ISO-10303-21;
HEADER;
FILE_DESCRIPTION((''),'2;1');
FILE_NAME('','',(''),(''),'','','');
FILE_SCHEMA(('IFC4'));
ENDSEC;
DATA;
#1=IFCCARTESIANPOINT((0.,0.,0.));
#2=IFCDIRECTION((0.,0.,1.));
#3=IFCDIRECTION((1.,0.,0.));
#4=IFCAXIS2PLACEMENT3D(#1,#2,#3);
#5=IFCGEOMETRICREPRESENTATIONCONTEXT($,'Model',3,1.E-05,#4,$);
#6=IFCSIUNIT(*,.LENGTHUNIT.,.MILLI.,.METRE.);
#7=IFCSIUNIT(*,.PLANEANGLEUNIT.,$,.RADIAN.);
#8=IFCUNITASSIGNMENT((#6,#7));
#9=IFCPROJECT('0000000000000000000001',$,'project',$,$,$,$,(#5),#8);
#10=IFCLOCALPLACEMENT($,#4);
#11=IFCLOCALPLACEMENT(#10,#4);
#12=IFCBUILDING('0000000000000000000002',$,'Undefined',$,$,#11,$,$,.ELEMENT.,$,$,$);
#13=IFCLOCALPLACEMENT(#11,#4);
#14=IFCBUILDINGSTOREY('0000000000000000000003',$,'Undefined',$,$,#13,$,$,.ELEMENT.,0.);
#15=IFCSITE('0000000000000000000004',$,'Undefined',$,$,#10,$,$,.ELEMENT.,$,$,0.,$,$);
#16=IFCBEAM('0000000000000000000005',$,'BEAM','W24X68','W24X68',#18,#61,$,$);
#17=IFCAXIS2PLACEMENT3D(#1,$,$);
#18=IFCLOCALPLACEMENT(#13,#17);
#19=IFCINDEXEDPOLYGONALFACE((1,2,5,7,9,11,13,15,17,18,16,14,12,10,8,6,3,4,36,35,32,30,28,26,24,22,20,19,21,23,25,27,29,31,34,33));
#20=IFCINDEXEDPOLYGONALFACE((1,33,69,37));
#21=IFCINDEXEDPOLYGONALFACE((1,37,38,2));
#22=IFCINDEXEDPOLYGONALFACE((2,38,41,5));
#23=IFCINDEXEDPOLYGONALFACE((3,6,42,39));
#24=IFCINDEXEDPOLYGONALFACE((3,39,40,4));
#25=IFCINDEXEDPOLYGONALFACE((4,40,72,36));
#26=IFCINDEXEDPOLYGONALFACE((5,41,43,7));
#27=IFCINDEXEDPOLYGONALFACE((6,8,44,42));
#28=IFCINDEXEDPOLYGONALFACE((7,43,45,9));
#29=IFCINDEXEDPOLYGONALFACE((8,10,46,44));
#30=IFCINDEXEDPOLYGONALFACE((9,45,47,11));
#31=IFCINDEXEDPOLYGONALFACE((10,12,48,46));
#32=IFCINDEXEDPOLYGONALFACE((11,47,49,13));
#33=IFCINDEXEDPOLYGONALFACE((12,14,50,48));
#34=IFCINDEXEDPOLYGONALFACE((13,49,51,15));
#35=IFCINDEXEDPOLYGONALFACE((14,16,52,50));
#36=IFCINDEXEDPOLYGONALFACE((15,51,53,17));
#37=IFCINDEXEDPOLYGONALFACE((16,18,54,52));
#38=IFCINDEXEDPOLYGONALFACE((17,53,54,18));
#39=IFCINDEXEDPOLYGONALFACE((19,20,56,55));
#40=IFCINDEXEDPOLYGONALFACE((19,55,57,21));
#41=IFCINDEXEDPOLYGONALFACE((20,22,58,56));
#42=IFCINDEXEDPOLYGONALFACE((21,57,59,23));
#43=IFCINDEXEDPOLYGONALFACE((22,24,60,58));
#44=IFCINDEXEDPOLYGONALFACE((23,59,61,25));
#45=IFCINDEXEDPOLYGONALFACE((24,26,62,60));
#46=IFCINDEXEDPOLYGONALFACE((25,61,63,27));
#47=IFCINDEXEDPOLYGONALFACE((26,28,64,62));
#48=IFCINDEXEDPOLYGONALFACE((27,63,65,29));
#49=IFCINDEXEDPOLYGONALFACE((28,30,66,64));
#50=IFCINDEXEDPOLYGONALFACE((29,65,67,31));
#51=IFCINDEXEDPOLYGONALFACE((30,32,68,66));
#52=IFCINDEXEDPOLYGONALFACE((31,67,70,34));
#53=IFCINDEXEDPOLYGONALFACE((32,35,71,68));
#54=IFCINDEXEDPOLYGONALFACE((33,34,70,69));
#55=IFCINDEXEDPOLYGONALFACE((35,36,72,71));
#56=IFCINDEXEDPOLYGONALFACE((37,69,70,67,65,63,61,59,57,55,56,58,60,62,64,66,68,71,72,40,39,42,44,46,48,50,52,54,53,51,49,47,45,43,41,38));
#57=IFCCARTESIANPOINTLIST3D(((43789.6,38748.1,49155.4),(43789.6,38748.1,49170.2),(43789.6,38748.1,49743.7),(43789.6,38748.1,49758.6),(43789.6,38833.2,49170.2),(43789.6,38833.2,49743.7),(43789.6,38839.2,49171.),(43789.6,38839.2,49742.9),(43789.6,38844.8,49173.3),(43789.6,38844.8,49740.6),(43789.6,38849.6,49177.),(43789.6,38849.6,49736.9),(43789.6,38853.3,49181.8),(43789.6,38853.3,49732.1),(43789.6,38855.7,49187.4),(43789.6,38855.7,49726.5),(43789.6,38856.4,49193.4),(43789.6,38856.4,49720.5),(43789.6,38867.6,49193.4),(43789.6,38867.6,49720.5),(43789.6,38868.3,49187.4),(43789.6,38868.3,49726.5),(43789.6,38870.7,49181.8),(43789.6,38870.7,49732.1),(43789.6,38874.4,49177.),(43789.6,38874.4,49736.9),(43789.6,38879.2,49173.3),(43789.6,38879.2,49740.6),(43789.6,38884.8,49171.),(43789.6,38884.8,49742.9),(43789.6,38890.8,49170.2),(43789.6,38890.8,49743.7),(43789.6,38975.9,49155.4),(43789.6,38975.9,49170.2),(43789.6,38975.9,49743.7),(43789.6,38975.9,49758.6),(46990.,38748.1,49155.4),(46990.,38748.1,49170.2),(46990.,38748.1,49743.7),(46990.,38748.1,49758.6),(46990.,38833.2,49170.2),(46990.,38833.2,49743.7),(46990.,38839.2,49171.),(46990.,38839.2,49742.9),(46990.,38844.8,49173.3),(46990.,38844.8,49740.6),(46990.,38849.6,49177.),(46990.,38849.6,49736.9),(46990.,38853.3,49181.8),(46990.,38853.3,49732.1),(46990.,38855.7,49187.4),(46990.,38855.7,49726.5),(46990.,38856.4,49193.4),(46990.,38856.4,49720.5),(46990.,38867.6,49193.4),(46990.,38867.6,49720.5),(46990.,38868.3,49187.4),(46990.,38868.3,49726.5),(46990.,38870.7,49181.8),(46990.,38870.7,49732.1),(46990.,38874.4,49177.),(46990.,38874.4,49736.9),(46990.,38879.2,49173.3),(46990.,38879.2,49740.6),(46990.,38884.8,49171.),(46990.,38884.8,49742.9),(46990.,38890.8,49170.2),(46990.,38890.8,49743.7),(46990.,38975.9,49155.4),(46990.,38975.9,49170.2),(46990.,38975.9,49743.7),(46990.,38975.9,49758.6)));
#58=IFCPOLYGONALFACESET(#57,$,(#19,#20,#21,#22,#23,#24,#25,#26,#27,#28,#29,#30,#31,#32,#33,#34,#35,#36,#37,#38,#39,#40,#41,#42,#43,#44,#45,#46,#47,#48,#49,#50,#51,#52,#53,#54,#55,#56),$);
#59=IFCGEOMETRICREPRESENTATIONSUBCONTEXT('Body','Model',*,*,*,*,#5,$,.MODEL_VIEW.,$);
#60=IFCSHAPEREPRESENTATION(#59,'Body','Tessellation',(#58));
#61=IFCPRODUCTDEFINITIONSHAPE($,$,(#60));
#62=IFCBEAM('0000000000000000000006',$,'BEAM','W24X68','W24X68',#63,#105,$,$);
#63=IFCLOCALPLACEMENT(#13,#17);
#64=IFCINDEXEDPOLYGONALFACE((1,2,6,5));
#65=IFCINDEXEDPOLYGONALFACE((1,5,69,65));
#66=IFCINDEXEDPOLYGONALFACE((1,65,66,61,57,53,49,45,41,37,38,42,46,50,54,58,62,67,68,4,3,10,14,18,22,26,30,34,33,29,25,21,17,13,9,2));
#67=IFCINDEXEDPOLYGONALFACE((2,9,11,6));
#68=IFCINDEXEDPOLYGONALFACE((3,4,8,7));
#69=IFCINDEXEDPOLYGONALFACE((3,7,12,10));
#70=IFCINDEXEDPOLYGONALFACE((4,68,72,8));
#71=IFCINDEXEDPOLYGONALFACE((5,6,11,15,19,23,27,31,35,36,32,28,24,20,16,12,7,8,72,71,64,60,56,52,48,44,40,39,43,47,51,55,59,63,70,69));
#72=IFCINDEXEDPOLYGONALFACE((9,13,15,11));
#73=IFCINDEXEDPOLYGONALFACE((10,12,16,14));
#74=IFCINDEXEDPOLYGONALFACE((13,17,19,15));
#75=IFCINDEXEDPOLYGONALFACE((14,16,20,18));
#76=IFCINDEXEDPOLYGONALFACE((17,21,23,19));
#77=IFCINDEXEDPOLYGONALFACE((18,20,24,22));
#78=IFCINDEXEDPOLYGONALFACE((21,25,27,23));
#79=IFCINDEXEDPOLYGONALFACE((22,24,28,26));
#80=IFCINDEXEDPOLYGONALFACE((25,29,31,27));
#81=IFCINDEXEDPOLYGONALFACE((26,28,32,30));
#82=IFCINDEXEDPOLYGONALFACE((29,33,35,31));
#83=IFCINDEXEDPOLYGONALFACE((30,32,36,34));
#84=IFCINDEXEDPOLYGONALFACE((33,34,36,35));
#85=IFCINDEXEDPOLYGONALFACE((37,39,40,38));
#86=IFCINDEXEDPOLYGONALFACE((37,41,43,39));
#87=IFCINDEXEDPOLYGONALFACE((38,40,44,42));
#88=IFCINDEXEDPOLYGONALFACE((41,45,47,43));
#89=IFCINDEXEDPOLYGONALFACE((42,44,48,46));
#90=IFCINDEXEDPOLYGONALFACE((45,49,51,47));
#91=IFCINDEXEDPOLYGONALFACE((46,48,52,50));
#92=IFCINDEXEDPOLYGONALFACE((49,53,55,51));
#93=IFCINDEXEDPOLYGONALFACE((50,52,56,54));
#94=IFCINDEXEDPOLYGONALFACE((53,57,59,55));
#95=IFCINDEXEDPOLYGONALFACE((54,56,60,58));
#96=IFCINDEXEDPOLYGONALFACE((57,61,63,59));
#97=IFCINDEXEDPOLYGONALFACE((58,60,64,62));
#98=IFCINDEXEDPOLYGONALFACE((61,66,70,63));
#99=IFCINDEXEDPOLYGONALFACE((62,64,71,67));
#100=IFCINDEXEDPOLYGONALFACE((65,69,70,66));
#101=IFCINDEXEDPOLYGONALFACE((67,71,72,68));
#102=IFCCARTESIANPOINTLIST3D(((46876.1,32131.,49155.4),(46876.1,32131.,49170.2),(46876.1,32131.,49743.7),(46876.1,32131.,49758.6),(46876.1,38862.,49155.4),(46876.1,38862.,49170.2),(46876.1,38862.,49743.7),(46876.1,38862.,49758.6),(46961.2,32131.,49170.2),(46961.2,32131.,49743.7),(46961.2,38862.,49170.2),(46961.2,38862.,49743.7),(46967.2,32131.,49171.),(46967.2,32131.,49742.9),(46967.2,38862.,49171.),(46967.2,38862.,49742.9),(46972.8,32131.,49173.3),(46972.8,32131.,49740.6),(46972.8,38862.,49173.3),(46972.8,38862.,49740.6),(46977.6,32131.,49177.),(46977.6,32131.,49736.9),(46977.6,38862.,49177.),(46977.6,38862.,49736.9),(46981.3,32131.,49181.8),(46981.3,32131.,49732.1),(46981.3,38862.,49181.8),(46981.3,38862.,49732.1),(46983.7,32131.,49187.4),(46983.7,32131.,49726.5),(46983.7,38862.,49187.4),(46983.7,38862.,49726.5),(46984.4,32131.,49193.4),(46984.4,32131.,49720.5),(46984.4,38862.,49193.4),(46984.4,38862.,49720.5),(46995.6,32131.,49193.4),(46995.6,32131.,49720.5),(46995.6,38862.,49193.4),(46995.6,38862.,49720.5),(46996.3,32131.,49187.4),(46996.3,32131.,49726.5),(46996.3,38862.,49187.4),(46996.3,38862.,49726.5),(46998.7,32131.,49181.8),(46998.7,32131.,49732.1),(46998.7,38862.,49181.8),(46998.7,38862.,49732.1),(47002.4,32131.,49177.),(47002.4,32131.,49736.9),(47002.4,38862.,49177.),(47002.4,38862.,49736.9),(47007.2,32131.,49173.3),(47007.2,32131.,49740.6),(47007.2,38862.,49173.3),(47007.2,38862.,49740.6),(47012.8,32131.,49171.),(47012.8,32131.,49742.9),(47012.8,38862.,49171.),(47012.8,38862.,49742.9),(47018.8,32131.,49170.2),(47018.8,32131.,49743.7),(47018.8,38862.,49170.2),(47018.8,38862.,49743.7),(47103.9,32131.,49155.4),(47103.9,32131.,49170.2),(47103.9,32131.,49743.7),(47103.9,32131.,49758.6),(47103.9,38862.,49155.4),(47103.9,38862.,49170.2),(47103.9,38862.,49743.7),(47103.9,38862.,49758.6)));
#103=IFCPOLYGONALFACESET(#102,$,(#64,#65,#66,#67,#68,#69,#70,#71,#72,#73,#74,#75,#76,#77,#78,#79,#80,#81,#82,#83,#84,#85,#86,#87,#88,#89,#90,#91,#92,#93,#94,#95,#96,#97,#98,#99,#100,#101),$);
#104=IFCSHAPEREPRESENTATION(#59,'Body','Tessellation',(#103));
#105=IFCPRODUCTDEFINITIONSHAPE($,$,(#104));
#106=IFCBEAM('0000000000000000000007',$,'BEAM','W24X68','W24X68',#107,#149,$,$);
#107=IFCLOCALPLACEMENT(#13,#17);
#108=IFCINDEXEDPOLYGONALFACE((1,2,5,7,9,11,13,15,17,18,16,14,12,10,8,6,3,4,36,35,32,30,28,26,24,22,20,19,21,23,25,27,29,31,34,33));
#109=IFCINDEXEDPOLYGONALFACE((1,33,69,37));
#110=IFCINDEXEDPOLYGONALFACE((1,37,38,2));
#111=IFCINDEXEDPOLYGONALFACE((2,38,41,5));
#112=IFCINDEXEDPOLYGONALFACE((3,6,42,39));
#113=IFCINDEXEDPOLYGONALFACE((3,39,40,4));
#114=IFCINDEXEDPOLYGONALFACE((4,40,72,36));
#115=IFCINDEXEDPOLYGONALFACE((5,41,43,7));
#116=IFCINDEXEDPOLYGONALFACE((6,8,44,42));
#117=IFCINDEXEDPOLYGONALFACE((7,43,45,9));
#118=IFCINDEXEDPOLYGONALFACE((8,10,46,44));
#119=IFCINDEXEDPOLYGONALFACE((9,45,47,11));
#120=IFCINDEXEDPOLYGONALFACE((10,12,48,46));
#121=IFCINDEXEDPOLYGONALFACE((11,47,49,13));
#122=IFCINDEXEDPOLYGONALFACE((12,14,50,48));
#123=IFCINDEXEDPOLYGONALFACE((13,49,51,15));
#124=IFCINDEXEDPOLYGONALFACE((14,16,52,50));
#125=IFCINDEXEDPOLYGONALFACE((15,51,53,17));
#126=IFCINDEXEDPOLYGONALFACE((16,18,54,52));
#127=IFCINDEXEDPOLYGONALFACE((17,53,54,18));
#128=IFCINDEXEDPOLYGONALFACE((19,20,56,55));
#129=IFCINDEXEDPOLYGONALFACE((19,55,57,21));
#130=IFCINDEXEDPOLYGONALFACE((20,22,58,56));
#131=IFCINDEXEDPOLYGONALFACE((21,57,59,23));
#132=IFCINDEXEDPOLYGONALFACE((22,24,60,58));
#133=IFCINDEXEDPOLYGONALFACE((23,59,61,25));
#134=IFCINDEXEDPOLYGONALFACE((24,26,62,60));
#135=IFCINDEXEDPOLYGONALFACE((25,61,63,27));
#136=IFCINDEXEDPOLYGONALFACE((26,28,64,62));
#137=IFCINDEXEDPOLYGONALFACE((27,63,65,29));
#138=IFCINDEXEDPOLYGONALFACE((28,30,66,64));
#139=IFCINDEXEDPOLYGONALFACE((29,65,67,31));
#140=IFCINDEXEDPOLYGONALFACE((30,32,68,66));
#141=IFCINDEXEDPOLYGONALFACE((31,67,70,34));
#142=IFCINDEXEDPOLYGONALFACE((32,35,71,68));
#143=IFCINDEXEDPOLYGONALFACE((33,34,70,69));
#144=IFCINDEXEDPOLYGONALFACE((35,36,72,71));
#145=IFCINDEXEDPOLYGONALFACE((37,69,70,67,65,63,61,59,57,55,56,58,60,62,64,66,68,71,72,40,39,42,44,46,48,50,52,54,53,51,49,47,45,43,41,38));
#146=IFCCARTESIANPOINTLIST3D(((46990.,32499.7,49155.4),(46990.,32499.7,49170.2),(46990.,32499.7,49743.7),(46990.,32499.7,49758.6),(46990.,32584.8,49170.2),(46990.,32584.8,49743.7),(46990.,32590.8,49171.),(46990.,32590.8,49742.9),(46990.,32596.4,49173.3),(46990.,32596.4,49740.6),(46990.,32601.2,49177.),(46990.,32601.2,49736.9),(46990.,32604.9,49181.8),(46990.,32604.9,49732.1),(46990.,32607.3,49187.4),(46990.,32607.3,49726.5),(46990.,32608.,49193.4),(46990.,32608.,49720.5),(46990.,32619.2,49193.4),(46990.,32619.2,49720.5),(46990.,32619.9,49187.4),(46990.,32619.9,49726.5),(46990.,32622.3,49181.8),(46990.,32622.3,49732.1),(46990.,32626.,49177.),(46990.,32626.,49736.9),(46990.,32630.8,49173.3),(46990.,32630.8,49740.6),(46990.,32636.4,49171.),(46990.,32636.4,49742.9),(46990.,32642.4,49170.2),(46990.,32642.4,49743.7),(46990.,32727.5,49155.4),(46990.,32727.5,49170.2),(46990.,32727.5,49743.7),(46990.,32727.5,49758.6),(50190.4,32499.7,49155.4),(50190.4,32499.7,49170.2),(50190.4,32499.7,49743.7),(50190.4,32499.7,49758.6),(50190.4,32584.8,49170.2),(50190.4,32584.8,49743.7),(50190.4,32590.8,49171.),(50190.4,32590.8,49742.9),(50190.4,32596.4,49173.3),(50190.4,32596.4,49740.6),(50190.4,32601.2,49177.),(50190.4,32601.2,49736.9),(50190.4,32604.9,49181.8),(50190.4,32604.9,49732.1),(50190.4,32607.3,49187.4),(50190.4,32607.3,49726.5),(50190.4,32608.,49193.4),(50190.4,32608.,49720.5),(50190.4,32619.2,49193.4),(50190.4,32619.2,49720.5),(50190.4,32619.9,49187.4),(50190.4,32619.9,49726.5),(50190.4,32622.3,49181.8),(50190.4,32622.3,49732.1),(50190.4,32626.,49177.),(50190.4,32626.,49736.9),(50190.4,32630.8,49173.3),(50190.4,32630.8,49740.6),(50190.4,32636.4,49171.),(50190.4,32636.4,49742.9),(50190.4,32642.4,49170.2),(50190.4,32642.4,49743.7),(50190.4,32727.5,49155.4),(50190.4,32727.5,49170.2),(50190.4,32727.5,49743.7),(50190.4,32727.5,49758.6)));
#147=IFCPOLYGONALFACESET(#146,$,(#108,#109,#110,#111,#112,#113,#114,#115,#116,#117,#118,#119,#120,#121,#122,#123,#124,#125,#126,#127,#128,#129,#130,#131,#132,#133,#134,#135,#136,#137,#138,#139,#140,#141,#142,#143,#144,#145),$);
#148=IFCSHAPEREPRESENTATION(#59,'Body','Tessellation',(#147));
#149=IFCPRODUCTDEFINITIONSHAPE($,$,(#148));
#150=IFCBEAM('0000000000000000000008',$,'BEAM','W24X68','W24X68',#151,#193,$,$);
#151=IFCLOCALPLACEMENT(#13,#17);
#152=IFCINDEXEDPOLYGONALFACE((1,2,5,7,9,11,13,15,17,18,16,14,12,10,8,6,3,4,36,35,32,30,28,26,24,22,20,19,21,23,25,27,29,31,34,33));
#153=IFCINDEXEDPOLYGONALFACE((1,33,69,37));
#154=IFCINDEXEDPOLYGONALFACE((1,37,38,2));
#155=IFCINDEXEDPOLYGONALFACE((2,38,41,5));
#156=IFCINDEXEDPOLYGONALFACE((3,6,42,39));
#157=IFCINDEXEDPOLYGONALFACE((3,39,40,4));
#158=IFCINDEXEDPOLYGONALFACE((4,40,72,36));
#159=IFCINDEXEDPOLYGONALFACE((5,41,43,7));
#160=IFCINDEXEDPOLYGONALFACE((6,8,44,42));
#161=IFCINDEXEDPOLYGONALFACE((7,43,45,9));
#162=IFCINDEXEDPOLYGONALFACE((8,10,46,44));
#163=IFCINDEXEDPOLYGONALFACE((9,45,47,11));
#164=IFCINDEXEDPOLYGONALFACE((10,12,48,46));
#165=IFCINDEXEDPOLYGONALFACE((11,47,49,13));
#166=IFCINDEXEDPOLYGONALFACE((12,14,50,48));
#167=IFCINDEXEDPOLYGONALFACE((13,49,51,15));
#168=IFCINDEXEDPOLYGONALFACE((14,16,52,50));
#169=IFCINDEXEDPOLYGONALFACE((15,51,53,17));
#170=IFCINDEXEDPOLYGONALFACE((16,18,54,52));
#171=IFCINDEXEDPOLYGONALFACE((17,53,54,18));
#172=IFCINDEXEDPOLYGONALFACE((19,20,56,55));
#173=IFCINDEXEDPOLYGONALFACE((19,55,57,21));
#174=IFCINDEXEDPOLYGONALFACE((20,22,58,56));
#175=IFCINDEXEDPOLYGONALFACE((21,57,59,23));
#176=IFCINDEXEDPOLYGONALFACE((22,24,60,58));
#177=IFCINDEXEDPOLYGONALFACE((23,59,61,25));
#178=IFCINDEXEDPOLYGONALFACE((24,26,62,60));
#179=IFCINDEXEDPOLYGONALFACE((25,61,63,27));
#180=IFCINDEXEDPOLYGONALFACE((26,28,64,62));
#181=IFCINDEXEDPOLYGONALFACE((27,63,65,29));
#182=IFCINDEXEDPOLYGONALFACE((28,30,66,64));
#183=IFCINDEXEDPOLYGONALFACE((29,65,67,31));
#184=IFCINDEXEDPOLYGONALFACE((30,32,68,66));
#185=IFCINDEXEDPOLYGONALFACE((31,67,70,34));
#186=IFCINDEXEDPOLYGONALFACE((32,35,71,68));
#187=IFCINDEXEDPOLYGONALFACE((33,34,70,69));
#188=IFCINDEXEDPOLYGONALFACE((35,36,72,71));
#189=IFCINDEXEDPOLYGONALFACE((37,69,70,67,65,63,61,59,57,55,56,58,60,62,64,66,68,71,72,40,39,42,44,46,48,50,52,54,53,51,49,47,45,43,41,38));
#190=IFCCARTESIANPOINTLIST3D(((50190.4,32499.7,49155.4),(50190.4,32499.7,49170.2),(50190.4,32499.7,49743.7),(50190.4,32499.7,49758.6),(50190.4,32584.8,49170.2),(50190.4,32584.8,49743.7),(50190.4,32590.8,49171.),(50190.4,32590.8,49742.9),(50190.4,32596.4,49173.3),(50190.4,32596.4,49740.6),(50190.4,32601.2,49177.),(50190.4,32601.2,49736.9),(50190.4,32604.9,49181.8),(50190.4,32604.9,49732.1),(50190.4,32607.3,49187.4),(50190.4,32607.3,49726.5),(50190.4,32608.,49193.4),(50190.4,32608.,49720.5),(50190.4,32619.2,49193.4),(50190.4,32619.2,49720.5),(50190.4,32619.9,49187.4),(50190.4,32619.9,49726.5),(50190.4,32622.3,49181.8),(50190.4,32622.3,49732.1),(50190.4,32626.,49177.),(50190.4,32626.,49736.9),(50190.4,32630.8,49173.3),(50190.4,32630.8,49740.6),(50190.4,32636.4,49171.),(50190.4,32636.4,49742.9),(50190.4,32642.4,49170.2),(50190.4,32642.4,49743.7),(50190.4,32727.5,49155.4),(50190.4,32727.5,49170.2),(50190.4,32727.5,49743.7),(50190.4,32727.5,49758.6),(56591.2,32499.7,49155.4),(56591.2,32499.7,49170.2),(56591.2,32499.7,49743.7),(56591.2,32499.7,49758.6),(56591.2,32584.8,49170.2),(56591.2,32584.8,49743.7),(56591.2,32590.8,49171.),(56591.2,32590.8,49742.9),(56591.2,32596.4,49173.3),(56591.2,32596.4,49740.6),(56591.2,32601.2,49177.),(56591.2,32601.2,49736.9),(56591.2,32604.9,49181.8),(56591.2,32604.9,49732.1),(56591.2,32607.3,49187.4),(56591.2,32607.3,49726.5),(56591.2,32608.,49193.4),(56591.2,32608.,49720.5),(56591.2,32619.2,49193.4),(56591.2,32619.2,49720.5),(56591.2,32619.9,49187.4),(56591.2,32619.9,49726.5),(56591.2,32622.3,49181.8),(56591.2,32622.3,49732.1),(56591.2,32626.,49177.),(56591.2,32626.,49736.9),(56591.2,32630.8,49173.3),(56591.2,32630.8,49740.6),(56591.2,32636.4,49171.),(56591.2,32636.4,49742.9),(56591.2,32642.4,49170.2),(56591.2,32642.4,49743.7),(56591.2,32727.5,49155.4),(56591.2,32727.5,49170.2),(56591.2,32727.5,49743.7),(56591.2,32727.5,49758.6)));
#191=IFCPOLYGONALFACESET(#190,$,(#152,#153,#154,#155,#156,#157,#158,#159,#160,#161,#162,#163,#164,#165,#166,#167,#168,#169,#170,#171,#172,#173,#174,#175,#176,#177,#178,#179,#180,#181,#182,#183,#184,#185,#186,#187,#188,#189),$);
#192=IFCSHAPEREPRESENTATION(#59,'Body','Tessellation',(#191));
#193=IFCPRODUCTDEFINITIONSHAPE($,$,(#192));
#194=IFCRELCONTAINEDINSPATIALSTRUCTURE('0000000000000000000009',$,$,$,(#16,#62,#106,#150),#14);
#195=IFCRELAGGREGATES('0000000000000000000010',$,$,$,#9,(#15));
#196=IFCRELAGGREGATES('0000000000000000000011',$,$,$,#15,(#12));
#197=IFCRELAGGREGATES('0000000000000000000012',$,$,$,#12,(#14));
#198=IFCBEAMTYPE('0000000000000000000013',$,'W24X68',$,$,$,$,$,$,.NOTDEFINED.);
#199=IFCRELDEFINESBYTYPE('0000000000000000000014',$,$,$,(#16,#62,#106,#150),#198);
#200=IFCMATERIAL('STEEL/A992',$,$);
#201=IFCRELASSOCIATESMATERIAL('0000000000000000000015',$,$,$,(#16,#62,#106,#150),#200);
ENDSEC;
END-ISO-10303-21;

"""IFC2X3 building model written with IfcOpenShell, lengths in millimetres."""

from ifc_helpers import new_model, si_unit, frame, origin_with_axes, origin_2d_with_axis, place, context, subcontext, project, spatial, i_section, extrude, material, type_object, element, save


model = new_model("IFC2X3")

# Units and contexts
model_context = context("Model", 3, precision=1e-05, world=origin_with_axes())
body_context = subcontext(model_context, "Body", "Model", "MODEL_VIEW")
ifc_project = project(units=[si_unit("LENGTHUNIT", "METRE", prefix="MILLI"), si_unit("PLANEANGLEUNIT", "RADIAN")], contexts=[model_context])

# Site, building, storey
site_placement = place(None, origin_with_axes())
site = spatial("IfcSite", under=ifc_project, at=site_placement, Name="Undefined", CompositionType="ELEMENT", RefElevation=0.0)
building_placement = place(site_placement, origin_with_axes())
building = spatial("IfcBuilding", under=site, at=building_placement, Name="Undefined", CompositionType="ELEMENT")
storey_placement = place(building_placement, origin_with_axes())
storey = spatial("IfcBuildingStorey", under=building, at=storey_placement, Name="Undefined", CompositionType="ELEMENT", Elevation=0.0)

# Shared definitions
ifc_material = material(Name="STEEL/A992")

# Beams
beam_type_1 = type_object("IfcBeamType", Name="W24X68", PredefinedType="NOTDEFINED")
beam_1_placement = place(storey_placement, frame((43789.6, 38862.0, 49457.0), z_axis=(0.0, 0.0, 1.0), x_axis=(1.0, 0.0, 0.0)))
element("IfcBeam", 1, at=beam_1_placement, inside=storey, type_object=beam_type_1, material=ifc_material, Name="BEAM", Description="W24X68", ObjectType="W24X68", context=body_context, shape_type="SweptSolid", body=[
    extrude(i_section(OverallWidth=227.8, OverallDepth=603.2, WebThickness=11.1, FlangeThickness=14.9, FilletRadius=23.2, at=origin_2d_with_axis()), frame((3200.4, 0.0, 0.0), z_axis=(-1.0, 0.0, 0.0), x_axis=(0.0, -1.0, 0.0)), (0.0, 0.0, 1.0), 3200.4),
])
beam_2_placement = place(storey_placement, frame((46990.0, 32131.0, 49457.0), z_axis=(0.0, 0.0, 1.0), x_axis=(0.0, 1.0, 0.0)))
element("IfcBeam", 2, at=beam_2_placement, inside=storey, type_object=beam_type_1, material=ifc_material, Name="BEAM", Description="W24X68", ObjectType="W24X68", context=body_context, shape_type="SweptSolid", body=[
    extrude(i_section(OverallWidth=227.8, OverallDepth=603.2, WebThickness=11.1, FlangeThickness=14.9, FilletRadius=23.2, at=origin_2d_with_axis()), frame((6731.0, 0.0, 0.0), z_axis=(-1.0, 0.0, 0.0), x_axis=(0.0, -1.0, 0.0)), (0.0, 0.0, 1.0), 6731.0),
])
beam_3_placement = place(storey_placement, frame((46990.0, 32613.6, 49457.0), z_axis=(0.0, 0.0, 1.0), x_axis=(1.0, 0.0, 0.0)))
element("IfcBeam", 3, at=beam_3_placement, inside=storey, type_object=beam_type_1, material=ifc_material, Name="BEAM", Description="W24X68", ObjectType="W24X68", context=body_context, shape_type="SweptSolid", body=[
    extrude(i_section(OverallWidth=227.8, OverallDepth=603.2, WebThickness=11.1, FlangeThickness=14.9, FilletRadius=23.2, at=origin_2d_with_axis()), frame((3200.4, 0.0, 0.0), z_axis=(-1.0, 0.0, 0.0), x_axis=(0.0, -1.0, 0.0)), (0.0, 0.0, 1.0), 3200.4),
])
beam_4_placement = place(storey_placement, frame((50190.4, 32613.6, 49457.0), z_axis=(0.0, 0.0, 1.0), x_axis=(1.0, 0.0, 0.0)))
element("IfcBeam", 4, at=beam_4_placement, inside=storey, type_object=beam_type_1, material=ifc_material, Name="BEAM", Description="W24X68", ObjectType="W24X68", context=body_context, shape_type="SweptSolid", body=[
    extrude(i_section(OverallWidth=227.8, OverallDepth=603.2, WebThickness=11.1, FlangeThickness=14.9, FilletRadius=23.2, at=origin_2d_with_axis()), frame((6400.8, 0.0, 0.0), z_axis=(-1.0, 0.0, 0.0), x_axis=(0.0, -1.0, 0.0)), (0.0, 0.0, 1.0), 6400.8),
])

save(model, "model.ifc")
